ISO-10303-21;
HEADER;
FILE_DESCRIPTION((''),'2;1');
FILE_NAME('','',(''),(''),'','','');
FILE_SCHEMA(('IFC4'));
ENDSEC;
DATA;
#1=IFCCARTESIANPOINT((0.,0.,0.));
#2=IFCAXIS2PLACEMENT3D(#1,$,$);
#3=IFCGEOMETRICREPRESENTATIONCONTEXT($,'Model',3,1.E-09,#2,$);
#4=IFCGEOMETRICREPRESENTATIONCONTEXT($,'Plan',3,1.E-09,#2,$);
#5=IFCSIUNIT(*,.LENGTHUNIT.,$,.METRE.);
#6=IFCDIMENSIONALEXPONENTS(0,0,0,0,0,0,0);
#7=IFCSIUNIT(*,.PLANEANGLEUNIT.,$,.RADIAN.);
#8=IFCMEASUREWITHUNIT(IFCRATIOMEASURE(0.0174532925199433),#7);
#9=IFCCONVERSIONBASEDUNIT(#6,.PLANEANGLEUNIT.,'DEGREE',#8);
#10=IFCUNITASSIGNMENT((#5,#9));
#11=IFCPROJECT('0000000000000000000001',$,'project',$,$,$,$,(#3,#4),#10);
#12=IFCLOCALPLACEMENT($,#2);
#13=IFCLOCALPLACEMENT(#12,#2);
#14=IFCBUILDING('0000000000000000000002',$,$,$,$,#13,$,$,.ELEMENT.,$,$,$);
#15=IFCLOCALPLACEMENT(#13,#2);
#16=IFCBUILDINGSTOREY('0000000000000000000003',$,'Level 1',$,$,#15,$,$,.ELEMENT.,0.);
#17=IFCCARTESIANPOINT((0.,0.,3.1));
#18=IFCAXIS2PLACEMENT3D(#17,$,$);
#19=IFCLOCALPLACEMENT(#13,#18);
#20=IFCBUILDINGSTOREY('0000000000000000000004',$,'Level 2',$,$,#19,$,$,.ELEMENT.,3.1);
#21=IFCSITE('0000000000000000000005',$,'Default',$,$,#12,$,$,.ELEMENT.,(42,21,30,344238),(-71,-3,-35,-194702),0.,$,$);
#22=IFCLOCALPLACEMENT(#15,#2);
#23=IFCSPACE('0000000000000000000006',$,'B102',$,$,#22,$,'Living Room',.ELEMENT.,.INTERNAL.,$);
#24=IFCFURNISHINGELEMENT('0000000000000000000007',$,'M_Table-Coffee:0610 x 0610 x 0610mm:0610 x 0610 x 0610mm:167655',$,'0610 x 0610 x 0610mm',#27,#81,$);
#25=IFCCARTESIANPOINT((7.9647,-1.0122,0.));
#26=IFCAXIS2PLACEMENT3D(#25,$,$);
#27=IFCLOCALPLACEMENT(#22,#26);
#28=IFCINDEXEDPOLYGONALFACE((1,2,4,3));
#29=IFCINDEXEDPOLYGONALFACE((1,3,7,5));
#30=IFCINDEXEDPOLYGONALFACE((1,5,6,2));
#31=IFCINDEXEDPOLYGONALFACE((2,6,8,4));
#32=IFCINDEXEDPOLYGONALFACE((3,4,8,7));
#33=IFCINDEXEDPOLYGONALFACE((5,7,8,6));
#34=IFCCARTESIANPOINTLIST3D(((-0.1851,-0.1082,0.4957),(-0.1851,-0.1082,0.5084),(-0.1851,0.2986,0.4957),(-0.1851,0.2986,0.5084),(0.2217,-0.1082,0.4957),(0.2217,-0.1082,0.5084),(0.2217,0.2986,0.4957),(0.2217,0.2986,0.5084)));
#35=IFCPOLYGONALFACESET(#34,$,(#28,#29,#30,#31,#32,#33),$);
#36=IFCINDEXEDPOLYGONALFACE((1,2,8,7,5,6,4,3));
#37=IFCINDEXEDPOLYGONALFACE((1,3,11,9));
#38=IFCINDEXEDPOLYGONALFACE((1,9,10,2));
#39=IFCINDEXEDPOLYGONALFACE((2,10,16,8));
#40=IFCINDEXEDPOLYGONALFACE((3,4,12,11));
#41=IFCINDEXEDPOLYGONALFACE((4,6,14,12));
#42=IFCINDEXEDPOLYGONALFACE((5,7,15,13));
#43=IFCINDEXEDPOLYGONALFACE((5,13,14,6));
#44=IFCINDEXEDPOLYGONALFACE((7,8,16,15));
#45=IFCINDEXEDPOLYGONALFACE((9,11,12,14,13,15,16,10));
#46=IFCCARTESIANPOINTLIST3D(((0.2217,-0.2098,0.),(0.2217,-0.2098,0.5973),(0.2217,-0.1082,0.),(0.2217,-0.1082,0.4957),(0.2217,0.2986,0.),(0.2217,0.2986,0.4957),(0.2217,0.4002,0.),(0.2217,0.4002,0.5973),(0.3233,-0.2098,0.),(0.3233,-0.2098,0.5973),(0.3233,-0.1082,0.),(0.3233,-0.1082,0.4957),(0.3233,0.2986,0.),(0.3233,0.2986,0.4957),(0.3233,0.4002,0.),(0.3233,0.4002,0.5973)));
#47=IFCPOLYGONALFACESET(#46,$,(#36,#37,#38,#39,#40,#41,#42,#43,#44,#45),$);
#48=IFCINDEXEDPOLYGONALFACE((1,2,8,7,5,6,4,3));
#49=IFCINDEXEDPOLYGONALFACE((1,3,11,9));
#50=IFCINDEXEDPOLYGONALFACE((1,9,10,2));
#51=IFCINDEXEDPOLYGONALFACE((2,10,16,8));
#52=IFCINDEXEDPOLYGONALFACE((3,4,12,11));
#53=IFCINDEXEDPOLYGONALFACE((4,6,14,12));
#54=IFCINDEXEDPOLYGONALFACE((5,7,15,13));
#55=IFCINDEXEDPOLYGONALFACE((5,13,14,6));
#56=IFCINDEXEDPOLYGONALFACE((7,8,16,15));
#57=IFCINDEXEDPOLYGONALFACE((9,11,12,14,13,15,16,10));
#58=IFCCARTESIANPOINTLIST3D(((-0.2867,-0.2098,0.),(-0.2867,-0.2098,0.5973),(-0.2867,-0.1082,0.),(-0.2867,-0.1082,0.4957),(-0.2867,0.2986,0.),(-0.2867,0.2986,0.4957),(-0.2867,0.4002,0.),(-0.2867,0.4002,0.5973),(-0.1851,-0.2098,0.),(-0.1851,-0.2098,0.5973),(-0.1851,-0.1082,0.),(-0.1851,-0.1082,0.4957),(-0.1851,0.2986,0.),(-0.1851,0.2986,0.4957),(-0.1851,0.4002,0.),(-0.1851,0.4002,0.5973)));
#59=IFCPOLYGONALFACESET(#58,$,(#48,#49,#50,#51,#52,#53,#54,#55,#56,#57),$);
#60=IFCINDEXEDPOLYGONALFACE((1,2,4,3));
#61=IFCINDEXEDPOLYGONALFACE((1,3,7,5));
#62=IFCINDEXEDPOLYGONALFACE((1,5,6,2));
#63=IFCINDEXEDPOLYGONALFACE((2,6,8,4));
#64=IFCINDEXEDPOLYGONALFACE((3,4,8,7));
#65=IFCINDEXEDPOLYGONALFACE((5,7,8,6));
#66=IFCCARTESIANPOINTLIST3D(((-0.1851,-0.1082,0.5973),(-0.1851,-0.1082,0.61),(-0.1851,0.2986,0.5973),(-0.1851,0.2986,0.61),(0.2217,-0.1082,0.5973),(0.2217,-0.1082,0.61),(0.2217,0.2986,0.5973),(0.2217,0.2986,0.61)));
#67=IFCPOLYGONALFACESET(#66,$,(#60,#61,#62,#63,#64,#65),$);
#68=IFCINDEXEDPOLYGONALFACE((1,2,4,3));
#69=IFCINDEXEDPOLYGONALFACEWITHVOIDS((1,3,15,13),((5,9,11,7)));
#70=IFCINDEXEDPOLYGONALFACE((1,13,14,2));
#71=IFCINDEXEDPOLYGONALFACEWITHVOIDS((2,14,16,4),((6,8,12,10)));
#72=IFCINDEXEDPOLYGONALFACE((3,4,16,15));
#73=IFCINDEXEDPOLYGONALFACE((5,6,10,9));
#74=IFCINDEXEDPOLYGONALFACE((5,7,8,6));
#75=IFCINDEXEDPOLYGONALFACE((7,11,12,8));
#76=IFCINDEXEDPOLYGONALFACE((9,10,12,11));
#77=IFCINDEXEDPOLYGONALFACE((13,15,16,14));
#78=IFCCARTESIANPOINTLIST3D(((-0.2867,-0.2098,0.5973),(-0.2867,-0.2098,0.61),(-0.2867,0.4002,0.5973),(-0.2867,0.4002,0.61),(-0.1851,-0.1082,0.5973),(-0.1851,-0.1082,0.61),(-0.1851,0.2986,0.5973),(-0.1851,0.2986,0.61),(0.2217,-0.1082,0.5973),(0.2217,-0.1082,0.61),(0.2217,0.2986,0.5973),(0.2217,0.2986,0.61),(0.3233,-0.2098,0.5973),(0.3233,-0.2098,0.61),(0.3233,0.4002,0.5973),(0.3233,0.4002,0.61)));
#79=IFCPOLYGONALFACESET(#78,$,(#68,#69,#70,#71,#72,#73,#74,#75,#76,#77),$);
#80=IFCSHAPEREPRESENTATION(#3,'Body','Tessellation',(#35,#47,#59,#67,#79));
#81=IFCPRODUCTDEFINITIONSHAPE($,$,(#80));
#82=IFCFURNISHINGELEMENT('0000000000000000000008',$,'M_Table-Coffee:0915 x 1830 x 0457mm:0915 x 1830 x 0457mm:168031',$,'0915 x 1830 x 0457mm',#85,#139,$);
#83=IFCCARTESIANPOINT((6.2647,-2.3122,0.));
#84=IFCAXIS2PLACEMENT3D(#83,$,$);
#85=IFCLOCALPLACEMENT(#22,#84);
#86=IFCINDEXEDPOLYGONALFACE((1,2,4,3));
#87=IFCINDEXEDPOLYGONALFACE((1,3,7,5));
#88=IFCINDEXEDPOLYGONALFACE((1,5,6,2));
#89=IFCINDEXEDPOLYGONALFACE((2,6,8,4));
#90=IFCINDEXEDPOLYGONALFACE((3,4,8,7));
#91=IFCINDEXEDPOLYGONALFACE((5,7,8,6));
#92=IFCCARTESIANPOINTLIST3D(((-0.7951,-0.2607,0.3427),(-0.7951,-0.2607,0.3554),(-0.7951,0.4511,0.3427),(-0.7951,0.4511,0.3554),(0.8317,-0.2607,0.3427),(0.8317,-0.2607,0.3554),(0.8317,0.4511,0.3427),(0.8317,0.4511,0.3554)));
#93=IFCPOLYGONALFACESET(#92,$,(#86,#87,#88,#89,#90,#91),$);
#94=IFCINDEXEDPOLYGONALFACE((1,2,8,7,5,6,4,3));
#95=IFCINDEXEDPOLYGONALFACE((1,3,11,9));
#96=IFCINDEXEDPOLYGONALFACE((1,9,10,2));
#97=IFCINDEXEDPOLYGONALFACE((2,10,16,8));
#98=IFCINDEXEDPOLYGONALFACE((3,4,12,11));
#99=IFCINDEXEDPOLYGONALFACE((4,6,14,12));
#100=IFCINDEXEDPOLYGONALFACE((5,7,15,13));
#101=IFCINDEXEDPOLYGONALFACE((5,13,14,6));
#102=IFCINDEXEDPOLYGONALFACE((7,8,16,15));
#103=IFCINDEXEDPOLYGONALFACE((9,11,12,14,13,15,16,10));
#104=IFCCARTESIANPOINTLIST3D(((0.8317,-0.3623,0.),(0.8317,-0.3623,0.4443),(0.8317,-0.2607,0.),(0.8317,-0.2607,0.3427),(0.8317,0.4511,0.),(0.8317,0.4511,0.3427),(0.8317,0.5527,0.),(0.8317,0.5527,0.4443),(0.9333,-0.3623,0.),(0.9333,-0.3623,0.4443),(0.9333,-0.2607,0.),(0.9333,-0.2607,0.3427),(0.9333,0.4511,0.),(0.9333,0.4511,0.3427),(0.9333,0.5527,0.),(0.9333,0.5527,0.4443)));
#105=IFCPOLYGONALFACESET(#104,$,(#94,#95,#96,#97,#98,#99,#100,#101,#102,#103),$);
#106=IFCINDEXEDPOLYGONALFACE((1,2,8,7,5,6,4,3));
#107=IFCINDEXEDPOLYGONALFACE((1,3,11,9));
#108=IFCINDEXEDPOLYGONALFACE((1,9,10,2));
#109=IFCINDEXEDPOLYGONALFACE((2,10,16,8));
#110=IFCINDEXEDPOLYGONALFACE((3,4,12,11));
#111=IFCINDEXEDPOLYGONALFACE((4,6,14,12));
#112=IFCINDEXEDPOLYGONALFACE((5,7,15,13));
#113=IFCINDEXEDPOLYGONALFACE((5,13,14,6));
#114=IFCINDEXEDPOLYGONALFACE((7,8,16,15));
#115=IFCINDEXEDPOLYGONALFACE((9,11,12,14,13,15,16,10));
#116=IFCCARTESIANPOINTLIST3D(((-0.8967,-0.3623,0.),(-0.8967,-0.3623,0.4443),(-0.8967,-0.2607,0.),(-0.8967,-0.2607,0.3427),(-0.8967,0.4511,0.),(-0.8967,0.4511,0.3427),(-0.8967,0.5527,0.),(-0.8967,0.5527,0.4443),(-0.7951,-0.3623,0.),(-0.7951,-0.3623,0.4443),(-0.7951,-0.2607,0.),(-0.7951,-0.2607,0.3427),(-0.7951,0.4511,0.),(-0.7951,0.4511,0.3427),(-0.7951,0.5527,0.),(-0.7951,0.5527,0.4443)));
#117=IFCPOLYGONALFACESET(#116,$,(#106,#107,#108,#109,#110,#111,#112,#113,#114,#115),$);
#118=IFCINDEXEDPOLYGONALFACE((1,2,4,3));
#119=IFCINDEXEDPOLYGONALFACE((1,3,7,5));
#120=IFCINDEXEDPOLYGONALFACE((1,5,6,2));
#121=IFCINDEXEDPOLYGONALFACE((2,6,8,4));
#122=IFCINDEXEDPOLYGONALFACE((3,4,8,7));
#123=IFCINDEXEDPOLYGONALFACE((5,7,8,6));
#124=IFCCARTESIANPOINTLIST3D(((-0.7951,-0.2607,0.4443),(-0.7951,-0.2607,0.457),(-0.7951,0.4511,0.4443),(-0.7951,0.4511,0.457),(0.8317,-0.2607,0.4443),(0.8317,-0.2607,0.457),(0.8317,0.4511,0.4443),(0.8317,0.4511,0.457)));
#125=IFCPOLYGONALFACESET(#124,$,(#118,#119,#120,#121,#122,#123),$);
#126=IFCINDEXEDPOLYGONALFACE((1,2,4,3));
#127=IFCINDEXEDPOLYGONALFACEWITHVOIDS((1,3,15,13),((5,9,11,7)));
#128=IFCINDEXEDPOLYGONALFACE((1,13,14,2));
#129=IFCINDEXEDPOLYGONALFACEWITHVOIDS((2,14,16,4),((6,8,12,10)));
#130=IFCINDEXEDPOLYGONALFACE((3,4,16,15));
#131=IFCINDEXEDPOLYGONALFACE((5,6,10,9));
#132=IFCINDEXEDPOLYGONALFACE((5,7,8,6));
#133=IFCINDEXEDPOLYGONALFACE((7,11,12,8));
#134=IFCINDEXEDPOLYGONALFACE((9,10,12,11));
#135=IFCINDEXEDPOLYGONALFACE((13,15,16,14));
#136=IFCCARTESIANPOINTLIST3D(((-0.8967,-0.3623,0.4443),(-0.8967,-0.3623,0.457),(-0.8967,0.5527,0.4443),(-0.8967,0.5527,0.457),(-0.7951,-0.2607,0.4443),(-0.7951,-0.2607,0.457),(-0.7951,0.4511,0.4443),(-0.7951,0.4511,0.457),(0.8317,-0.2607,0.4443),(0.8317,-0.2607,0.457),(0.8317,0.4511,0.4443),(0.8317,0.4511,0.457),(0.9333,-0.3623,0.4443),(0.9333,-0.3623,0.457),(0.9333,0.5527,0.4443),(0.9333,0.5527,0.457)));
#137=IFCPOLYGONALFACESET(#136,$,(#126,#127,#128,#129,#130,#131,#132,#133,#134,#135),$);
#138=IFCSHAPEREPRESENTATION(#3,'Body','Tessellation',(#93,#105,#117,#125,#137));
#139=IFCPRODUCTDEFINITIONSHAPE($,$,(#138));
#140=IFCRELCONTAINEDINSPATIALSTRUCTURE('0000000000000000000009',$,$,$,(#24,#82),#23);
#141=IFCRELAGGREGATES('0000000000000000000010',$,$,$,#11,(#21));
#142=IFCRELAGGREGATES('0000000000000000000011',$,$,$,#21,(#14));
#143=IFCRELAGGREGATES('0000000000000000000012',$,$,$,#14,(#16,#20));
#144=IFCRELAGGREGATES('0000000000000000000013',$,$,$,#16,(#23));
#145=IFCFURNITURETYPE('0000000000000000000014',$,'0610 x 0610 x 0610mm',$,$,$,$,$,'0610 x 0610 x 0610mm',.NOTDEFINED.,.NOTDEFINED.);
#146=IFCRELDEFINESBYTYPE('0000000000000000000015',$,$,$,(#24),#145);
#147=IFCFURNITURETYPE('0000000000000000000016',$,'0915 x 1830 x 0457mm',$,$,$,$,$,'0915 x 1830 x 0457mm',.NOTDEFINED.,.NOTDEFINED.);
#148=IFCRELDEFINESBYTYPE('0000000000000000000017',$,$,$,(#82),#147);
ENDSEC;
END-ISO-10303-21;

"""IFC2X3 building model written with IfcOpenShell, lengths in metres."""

from ifc_helpers import new_model, entity, si_unit, converted_unit, frame, origin, origin_2d_with_axis, place, context, project, spatial, polyline, rectangle, outline, extrude, source, transform, mapped, type_object, type_shapes, element, save


model = new_model("IFC2X3")

# Units and contexts
model_context = context("Model", 3, precision=1e-09, world=origin())
plan_context = context("Plan", 3, precision=1e-09, world=origin())
ifc_project = project(units=[si_unit("LENGTHUNIT", "METRE"), converted_unit("PLANEANGLEUNIT", "DEGREE", entity("IfcRatioMeasure", 0.0174532925199433), si_unit("PLANEANGLEUNIT", "RADIAN"), dimensions=[0, 0, 0, 0, 0, 0, 0])], contexts=[model_context, plan_context])

# Site, building, storey
site_placement = place(None, origin())
site = spatial("IfcSite", under=ifc_project, at=site_placement, Name="Default", CompositionType="ELEMENT", RefLatitude=(42, 21, 30, 344238), RefLongitude=(-71, -3, -35, -194702), RefElevation=0.0)
building_placement = place(site_placement, origin())
building = spatial("IfcBuilding", under=site, at=building_placement, CompositionType="ELEMENT")
storey_1_placement = place(building_placement, origin())
storey_1 = spatial("IfcBuildingStorey", under=building, at=storey_1_placement, Name="Level 1", CompositionType="ELEMENT", Elevation=0.0)

# Shared definitions
placement_1 = place(storey_1_placement, origin())

# Shared definitions
storey_2_placement = place(building_placement, frame((0.0, 0.0, 3.1)))
storey_2 = spatial("IfcBuildingStorey", under=building, at=storey_2_placement, Name="Level 2", CompositionType="ELEMENT", Elevation=3.1)

# Shared definitions
space_1 = spatial("IfcSpace", under=storey_1, at=placement_1, Name="B102", LongName="Living Room", CompositionType="ELEMENT", InteriorOrExteriorSpace="INTERNAL")

# Furnishing elements
furniture_type_1 = type_object("IfcFurnitureType", Name="0610 x 0610 x 0610mm", ElementType="0610 x 0610 x 0610mm", AssemblyPlace="NOTDEFINED")
shared_shape_1 = source(origin(), model_context, "Body", "SweptSolid", [
    extrude(rectangle(XDim=0.4068, YDim=0.4068, at=origin_2d_with_axis()), frame((0.0183, 0.0952, 0.4957), z_axis=(0.0, 0.0, 1.0), x_axis=(-1.0, 0.0, 0.0)), (0.0, 0.0, 1.0), 0.0127),
    extrude(outline(polyline([(-0.2732, -0.305), (0.324, -0.305), (0.324, 0.305), (-0.2732, 0.305), (-0.2732, 0.2034), (0.2225, 0.2034), (0.2225, -0.2034), (-0.2732, -0.2034), (-0.2732, -0.305)])), frame((0.2217, 0.0952, 0.2732), z_axis=(1.0, 0.0, 0.0), x_axis=(0.0, 0.0, 1.0)), (0.0, 0.0, 1.0), 0.1016),
    extrude(outline(polyline([(-0.305, -0.3241), (0.305, -0.3241), (0.305, 0.2733), (0.2034, 0.2733), (0.2034, -0.2224), (-0.2034, -0.2224), (-0.2034, 0.2733), (-0.305, 0.2733), (-0.305, -0.3241)])), frame((-0.2867, 0.0952, 0.2733), z_axis=(1.0, 0.0, 0.0), x_axis=(0.0, -1.0, 0.0)), (0.0, 0.0, 1.0), 0.1016),
    extrude(rectangle(XDim=0.4068, YDim=0.4068, at=origin_2d_with_axis()), frame((0.0183, 0.0952, 0.5973), z_axis=(0.0, 0.0, 1.0), x_axis=(-1.0, 0.0, 0.0)), (0.0, 0.0, 1.0), 0.0127),
    extrude(outline(polyline([(-0.305, -0.305), (0.305, -0.305), (0.305, 0.305), (-0.305, 0.305), (-0.305, -0.305)]), holes=[polyline([(-0.2034, -0.2034), (-0.2034, 0.2034), (0.2034, 0.2034), (0.2034, -0.2034), (-0.2034, -0.2034)])]), frame((0.0183, 0.0952, 0.5973), z_axis=(0.0, 0.0, 1.0), x_axis=(-1.0, 0.0, 0.0)), (0.0, 0.0, 1.0), 0.0127),
])
type_shapes(furniture_type_1, [shared_shape_1])
for number, where, name in (
    (1, (7.9647, -1.0122, 0.0), "M_Table-Coffee:0610 x 0610 x 0610mm:0610 x 0610 x 0610mm:167655"),
):
    element("IfcFurnishingElement", number, at=place(placement_1, frame(where)), inside=space_1, type_object=furniture_type_1, Name=name, ObjectType="0610 x 0610 x 0610mm", context=model_context, shape_type="MappedRepresentation", body=[
        mapped(shared_shape_1, transform((0.0, 0.0, 0.0), scale=1.0)),
    ])
furniture_type_2 = type_object("IfcFurnitureType", Name="0915 x 1830 x 0457mm", ElementType="0915 x 1830 x 0457mm", AssemblyPlace="NOTDEFINED")
shared_shape_2 = source(origin(), model_context, "Body", "SweptSolid", [
    extrude(rectangle(XDim=1.6268, YDim=0.7118, at=origin_2d_with_axis()), frame((0.0183, 0.0952, 0.3427), z_axis=(0.0, 0.0, 1.0), x_axis=(-1.0, 0.0, 0.0)), (0.0, 0.0, 1.0), 0.0127),
    extrude(outline(polyline([(-0.1967, -0.4575), (0.2475, -0.4575), (0.2475, 0.4575), (-0.1967, 0.4575), (-0.1967, 0.3559), (0.146, 0.3559), (0.146, -0.3559), (-0.1967, -0.3559), (-0.1967, -0.4575)])), frame((0.8317, 0.0952, 0.1967), z_axis=(1.0, 0.0, 0.0), x_axis=(0.0, 0.0, 1.0)), (0.0, 0.0, 1.0), 0.1016),
    extrude(outline(polyline([(-0.4575, -0.2476), (0.4575, -0.2476), (0.4575, 0.1968), (0.3559, 0.1968), (0.3559, -0.1459), (-0.3559, -0.1459), (-0.3559, 0.1968), (-0.4575, 0.1968), (-0.4575, -0.2476)])), frame((-0.8967, 0.0952, 0.1968), z_axis=(1.0, 0.0, 0.0), x_axis=(0.0, -1.0, 0.0)), (0.0, 0.0, 1.0), 0.1016),
    extrude(rectangle(XDim=1.6268, YDim=0.7118, at=origin_2d_with_axis()), frame((0.0183, 0.0952, 0.4443), z_axis=(0.0, 0.0, 1.0), x_axis=(-1.0, 0.0, 0.0)), (0.0, 0.0, 1.0), 0.0127),
    extrude(outline(polyline([(-0.915, -0.4575), (0.915, -0.4575), (0.915, 0.4575), (-0.915, 0.4575), (-0.915, -0.4575)]), holes=[polyline([(-0.8134, -0.3559), (-0.8134, 0.3559), (0.8134, 0.3559), (0.8134, -0.3559), (-0.8134, -0.3559)])]), frame((0.0183, 0.0952, 0.4443), z_axis=(0.0, 0.0, 1.0), x_axis=(-1.0, 0.0, 0.0)), (0.0, 0.0, 1.0), 0.0127),
])
type_shapes(furniture_type_2, [shared_shape_2])
furnishing_1_placement = place(placement_1, frame((6.2647, -2.3122, 0.0)))
element("IfcFurnishingElement", 2, at=furnishing_1_placement, inside=space_1, type_object=furniture_type_2, Name="M_Table-Coffee:0915 x 1830 x 0457mm:0915 x 1830 x 0457mm:168031", ObjectType="0915 x 1830 x 0457mm", context=model_context, shape_type="MappedRepresentation", body=[
    mapped(shared_shape_2, transform((0.0, 0.0, 0.0), scale=1.0)),
])

save(model, "model.ifc")
